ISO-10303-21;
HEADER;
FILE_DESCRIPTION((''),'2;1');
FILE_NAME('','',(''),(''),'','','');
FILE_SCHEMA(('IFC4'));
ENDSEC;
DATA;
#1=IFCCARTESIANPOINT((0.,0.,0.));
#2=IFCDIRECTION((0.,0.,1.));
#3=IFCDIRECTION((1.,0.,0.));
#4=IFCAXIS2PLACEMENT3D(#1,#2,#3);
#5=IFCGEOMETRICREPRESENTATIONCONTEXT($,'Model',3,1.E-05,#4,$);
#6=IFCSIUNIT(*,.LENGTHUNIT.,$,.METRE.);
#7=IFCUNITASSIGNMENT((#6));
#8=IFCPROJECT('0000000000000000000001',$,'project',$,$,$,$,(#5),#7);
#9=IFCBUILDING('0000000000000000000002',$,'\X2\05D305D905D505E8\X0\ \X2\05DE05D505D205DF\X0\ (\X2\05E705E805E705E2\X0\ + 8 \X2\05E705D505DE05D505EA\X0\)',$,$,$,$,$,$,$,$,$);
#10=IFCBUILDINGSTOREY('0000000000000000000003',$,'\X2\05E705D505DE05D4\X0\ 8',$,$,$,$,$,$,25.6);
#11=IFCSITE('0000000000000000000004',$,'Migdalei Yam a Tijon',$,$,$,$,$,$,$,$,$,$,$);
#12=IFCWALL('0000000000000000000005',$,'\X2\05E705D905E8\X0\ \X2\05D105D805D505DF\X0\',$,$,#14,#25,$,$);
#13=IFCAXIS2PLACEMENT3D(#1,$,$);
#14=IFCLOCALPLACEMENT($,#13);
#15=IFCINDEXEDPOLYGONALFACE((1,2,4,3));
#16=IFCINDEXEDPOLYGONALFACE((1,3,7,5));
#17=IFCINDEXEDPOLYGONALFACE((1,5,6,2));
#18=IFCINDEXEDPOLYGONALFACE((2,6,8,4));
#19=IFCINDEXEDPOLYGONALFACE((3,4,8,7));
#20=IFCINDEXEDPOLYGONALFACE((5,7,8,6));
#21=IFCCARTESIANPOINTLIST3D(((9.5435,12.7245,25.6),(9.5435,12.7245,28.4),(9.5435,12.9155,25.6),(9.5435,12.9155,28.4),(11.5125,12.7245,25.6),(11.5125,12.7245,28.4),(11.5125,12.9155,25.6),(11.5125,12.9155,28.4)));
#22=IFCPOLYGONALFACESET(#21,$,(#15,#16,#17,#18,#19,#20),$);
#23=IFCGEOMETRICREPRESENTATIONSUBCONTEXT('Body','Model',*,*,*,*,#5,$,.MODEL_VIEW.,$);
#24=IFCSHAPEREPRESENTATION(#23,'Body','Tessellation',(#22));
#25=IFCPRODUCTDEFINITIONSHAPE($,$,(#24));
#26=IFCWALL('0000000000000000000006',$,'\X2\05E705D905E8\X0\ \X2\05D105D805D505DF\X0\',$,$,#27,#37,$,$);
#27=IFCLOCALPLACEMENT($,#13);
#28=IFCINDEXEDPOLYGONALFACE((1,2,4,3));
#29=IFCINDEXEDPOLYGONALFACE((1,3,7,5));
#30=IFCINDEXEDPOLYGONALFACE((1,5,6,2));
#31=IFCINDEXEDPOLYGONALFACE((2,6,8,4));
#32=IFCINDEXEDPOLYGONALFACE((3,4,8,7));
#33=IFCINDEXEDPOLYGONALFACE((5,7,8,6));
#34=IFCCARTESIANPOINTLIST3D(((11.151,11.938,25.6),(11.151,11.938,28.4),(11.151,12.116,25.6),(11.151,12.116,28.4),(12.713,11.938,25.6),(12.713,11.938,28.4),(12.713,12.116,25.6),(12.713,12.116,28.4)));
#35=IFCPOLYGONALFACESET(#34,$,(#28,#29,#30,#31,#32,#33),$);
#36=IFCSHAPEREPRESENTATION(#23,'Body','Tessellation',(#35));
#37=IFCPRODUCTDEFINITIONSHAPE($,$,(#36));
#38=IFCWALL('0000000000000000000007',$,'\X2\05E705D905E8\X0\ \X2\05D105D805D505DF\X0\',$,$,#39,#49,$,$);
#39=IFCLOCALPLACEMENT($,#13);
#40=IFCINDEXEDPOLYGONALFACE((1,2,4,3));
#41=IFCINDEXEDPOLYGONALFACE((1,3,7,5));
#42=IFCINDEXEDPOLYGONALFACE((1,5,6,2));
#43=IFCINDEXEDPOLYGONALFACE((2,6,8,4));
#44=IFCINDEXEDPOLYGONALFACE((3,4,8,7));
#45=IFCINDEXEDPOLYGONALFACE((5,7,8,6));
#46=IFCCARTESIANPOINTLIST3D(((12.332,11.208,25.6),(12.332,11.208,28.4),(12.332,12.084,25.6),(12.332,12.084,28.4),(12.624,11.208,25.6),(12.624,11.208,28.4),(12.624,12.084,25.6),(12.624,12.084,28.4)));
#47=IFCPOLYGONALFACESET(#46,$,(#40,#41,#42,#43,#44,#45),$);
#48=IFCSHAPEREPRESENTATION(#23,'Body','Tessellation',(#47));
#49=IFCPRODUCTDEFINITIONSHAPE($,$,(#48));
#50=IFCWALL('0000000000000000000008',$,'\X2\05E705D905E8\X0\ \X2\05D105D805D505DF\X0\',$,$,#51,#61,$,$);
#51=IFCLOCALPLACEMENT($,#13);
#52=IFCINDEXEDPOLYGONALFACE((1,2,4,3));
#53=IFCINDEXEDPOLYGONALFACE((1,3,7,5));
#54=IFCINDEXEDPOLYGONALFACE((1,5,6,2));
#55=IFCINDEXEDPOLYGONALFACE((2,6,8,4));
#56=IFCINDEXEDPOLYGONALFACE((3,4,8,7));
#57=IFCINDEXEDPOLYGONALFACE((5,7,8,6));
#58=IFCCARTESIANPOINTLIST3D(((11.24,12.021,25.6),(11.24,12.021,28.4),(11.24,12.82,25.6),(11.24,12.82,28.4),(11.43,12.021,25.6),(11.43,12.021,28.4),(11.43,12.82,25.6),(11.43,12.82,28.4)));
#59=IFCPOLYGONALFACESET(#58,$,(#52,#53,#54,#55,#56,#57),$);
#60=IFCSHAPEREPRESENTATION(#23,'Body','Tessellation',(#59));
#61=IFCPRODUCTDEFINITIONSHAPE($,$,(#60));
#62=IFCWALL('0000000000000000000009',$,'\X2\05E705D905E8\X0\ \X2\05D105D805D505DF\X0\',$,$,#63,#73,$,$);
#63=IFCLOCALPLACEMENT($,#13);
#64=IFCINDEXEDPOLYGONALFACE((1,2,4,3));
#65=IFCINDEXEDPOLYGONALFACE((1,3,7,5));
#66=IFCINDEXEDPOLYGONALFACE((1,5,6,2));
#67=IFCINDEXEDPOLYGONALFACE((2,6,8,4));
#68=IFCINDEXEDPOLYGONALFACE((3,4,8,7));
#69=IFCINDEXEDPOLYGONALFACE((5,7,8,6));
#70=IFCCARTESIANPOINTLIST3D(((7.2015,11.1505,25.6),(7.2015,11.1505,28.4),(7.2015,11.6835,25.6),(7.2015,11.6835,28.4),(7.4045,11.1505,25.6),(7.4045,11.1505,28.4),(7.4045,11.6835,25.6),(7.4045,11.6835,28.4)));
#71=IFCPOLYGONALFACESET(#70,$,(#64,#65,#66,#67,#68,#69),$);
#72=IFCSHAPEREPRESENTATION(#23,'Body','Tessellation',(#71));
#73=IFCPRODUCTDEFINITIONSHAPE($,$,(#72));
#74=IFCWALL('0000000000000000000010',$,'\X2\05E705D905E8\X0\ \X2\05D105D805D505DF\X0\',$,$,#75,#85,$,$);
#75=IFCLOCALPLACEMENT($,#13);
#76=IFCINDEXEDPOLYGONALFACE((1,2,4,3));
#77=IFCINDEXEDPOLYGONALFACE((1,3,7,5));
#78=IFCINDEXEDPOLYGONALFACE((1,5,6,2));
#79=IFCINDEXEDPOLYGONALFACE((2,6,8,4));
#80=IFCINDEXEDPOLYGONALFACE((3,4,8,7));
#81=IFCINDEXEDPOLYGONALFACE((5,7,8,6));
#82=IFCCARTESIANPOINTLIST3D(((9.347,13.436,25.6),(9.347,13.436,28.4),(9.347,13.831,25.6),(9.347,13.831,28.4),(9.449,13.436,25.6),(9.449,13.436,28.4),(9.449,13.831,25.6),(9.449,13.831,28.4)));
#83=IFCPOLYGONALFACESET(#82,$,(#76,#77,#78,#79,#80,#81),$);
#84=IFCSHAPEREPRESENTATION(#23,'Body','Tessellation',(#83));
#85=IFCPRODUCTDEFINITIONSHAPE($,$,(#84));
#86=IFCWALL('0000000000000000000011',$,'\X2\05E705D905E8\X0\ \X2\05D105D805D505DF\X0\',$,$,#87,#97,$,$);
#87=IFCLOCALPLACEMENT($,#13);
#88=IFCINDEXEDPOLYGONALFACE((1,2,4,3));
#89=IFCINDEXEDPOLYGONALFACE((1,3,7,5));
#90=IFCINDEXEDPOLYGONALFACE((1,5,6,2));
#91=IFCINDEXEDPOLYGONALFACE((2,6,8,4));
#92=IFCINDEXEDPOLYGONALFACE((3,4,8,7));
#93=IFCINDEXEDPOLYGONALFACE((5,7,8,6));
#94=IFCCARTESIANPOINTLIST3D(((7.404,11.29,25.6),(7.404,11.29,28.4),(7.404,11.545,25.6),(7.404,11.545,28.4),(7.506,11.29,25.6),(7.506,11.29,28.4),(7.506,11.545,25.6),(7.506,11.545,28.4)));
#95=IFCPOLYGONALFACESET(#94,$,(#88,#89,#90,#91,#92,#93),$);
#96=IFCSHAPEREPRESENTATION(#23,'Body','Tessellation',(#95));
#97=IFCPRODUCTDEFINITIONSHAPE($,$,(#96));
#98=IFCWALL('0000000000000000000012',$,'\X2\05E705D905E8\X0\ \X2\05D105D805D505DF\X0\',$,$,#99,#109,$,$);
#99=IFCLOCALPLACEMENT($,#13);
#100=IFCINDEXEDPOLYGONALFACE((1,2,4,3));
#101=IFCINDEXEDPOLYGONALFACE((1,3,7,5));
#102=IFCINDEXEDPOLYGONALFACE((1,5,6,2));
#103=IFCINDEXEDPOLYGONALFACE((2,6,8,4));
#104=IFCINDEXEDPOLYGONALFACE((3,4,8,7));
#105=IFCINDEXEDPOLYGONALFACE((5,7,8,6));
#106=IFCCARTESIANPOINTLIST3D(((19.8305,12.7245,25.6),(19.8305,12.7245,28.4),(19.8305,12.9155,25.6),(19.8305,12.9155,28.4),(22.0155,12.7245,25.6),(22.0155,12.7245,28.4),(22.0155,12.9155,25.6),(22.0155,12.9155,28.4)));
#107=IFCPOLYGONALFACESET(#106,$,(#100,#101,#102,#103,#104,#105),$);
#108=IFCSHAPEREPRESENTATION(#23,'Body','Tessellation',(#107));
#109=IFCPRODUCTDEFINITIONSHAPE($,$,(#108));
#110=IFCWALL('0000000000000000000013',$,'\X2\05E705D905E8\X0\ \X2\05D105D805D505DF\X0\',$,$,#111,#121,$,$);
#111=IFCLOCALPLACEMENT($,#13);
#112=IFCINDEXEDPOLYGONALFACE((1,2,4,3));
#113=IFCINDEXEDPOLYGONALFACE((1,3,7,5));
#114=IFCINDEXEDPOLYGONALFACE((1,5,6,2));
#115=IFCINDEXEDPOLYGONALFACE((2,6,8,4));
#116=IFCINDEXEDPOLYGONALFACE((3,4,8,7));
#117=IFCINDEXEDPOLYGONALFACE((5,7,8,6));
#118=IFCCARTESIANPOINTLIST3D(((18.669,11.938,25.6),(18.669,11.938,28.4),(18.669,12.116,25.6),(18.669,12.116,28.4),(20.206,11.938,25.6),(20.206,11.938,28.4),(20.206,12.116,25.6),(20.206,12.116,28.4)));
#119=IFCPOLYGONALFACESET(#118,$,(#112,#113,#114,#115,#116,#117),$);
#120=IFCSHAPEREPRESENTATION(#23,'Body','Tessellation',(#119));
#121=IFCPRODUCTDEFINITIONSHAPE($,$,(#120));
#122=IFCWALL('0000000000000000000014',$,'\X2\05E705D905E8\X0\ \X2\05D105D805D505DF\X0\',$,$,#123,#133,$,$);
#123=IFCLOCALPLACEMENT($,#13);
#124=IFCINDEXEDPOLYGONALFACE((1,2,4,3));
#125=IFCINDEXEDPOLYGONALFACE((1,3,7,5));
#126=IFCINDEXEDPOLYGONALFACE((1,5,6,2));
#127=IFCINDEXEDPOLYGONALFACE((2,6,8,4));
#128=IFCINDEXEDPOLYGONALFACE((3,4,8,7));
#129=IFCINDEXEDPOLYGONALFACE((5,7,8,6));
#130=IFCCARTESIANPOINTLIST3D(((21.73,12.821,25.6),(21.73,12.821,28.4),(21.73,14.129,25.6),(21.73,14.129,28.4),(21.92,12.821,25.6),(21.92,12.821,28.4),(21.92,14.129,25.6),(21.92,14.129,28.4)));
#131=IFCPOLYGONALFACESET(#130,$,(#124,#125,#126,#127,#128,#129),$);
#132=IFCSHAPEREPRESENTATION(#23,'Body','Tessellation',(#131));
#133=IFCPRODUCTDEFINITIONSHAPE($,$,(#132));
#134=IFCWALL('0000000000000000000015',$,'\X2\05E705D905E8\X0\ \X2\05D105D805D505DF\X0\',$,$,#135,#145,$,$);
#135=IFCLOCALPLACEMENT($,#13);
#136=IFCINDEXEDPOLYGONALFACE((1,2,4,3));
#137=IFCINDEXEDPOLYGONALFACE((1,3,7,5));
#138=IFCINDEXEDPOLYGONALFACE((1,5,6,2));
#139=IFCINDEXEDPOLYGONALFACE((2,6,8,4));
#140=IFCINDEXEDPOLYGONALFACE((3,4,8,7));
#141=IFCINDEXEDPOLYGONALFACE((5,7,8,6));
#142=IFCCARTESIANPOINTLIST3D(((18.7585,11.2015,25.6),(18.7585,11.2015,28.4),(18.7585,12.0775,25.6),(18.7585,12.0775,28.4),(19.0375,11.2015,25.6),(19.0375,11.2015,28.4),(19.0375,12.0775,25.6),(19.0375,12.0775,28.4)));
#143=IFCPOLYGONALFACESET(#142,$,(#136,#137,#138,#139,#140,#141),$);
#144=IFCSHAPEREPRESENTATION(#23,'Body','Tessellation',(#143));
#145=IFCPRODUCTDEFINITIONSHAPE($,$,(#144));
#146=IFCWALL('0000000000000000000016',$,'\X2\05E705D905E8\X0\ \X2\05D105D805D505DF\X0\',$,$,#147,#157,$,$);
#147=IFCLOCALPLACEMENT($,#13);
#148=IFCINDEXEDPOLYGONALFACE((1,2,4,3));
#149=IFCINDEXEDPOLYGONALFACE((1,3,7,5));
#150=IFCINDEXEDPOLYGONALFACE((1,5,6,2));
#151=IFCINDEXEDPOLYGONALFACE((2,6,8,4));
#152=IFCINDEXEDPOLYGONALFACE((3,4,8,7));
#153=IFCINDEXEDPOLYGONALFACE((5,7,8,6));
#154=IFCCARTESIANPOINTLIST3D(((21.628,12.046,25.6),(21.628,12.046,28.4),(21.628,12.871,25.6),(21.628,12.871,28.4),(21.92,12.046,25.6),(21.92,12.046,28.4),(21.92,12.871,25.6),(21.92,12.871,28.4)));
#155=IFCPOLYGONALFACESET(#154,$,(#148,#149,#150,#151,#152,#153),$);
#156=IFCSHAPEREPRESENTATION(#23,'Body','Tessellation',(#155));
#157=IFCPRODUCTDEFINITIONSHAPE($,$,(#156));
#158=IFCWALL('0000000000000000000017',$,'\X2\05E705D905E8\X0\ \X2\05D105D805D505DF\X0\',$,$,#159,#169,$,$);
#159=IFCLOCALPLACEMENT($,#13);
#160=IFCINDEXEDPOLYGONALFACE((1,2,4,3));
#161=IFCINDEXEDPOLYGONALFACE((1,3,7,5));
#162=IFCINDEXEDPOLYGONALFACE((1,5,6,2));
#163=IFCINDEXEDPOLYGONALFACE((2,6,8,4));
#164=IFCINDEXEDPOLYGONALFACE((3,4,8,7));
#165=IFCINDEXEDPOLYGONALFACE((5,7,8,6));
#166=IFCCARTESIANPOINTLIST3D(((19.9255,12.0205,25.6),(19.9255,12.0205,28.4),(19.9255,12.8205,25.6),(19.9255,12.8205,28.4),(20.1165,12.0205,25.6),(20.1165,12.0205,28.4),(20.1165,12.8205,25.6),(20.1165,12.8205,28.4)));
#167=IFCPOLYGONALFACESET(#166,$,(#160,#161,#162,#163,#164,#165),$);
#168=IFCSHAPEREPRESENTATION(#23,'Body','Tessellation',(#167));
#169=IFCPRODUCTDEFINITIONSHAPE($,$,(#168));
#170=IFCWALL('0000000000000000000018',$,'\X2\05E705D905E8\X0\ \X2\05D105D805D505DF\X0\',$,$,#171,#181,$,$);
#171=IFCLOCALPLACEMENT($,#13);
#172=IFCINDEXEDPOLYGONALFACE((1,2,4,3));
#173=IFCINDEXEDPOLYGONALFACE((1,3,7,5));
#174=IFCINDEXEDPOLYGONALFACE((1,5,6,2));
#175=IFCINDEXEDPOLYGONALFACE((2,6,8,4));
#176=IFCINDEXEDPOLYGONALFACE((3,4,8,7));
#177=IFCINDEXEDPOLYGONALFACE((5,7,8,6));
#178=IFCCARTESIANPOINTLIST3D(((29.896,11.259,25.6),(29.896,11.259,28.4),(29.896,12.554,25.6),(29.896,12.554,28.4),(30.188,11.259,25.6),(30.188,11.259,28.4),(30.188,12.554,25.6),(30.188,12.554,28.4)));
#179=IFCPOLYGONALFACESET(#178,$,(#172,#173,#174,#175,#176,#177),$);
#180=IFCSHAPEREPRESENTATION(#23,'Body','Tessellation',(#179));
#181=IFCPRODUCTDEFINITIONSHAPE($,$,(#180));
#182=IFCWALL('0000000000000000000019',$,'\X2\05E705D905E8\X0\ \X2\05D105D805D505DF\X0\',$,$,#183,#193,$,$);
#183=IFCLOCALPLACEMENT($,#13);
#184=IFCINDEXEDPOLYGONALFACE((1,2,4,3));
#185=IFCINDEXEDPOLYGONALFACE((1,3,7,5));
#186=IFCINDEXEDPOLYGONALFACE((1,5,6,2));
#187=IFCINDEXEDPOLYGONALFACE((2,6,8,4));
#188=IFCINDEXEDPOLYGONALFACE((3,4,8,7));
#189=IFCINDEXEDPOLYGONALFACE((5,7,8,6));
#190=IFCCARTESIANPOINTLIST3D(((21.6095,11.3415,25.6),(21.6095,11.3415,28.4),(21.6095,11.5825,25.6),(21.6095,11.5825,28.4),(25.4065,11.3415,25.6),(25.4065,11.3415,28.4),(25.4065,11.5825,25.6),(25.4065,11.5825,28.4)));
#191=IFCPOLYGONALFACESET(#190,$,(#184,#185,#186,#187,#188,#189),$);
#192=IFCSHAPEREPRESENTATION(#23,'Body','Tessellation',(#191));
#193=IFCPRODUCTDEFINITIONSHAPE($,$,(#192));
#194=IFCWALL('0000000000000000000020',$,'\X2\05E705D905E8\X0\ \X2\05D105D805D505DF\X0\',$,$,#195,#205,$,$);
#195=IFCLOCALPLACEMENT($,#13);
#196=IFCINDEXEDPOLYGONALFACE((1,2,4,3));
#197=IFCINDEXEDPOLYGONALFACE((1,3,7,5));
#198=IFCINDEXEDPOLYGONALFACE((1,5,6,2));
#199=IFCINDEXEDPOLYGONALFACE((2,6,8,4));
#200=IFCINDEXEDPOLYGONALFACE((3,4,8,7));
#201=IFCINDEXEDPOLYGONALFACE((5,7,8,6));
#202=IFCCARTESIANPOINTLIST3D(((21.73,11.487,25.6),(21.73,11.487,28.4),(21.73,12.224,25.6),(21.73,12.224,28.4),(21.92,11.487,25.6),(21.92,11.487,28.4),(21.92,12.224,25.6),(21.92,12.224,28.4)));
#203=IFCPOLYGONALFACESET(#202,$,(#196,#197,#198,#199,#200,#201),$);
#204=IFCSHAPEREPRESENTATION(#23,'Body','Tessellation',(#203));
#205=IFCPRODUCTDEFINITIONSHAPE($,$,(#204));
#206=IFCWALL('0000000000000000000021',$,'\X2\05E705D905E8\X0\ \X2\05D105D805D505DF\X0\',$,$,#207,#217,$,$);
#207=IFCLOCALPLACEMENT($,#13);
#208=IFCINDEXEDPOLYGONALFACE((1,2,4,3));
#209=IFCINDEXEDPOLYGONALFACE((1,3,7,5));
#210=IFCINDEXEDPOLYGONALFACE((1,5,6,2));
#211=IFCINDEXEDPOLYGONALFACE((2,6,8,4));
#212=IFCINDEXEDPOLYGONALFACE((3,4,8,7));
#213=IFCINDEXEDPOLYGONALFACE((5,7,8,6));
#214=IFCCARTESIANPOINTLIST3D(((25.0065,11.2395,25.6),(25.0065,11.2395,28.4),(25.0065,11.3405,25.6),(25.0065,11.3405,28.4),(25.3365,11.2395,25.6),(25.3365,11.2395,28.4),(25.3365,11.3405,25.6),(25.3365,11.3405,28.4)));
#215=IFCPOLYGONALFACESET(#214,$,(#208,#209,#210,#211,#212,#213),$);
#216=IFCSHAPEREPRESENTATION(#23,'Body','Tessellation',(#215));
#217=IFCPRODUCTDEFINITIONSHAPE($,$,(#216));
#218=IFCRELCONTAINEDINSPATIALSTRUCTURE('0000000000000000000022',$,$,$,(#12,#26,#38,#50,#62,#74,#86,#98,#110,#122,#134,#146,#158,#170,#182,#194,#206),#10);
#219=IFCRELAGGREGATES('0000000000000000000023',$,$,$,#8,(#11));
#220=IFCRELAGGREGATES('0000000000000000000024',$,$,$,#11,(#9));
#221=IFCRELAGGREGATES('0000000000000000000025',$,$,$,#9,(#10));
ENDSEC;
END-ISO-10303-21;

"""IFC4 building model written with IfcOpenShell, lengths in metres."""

from ifc_helpers import new_model, si_unit, frame, origin_with_axes, context, subcontext, project, spatial, line, indexed_curve, outline, extrude, element, save


model = new_model("IFC4")

# Units and contexts
model_context = context("Model", 3, precision=1e-05, world=origin_with_axes())
body_context = subcontext(model_context, "Body", "Model", "MODEL_VIEW")
ifc_project = project(units=[si_unit("LENGTHUNIT", "METRE")], contexts=[model_context])

# Site, building, storey
site = spatial("IfcSite", under=ifc_project, Name="Migdalei Yam a Tijon")
building = spatial("IfcBuilding", under=site, Name="דיור מוגן (קרקע + 8 קומות)")
storey = spatial("IfcBuildingStorey", under=building, Name="קומה 8", Elevation=25.6)

# Walls
element("IfcWall", 1, inside=storey, Name="קיר בטון", context=body_context, shape_type="SweptSolid", body=[
    extrude(outline(indexed_curve([(0.0, 0.0), (1.969, 0.0), (1.969, 0.191), (0.0, 0.191)], segments=[line(1, 2, 3, 4, 1)])), frame((9.5435, 12.7245, 25.6), z_axis=(0.0, 0.0, 1.0), x_axis=(1.0, 0.0, 0.0)), (0.0, 0.0, 1.0), 2.8),
])
element("IfcWall", 2, inside=storey, Name="קיר בטון", context=body_context, shape_type="SweptSolid", body=[
    extrude(outline(indexed_curve([(0.0, 0.0), (1.562, 0.0), (1.562, 0.178), (0.0, 0.178)], segments=[line(1, 2, 3, 4, 1)])), frame((11.151, 11.938, 25.6), z_axis=(0.0, 0.0, 1.0), x_axis=(1.0, 0.0, 0.0)), (0.0, 0.0, 1.0), 2.8),
])
element("IfcWall", 3, inside=storey, Name="קיר בטון", context=body_context, shape_type="SweptSolid", body=[
    extrude(outline(indexed_curve([(0.0, 0.0), (0.292, 0.0), (0.292, 0.876), (0.0, 0.876)], segments=[line(1, 2, 3, 4, 1)])), frame((12.332, 11.208, 25.6), z_axis=(0.0, 0.0, 1.0), x_axis=(1.0, 0.0, 0.0)), (0.0, 0.0, 1.0), 2.8),
])
element("IfcWall", 4, inside=storey, Name="קיר בטון", context=body_context, shape_type="SweptSolid", body=[
    extrude(outline(indexed_curve([(0.0, 0.0), (0.19, 0.0), (0.19, 0.799), (0.0, 0.799)], segments=[line(1, 2, 3, 4, 1)])), frame((11.24, 12.021, 25.6), z_axis=(0.0, 0.0, 1.0), x_axis=(1.0, 0.0, 0.0)), (0.0, 0.0, 1.0), 2.8),
])
element("IfcWall", 5, inside=storey, Name="קיר בטון", context=body_context, shape_type="SweptSolid", body=[
    extrude(outline(indexed_curve([(0.0, 0.0), (0.203, 0.0), (0.203, 0.533), (0.0, 0.533)], segments=[line(1, 2, 3, 4, 1)])), frame((7.2015, 11.1505, 25.6), z_axis=(0.0, 0.0, 1.0), x_axis=(1.0, 0.0, 0.0)), (0.0, 0.0, 1.0), 2.8),
])
element("IfcWall", 6, inside=storey, Name="קיר בטון", context=body_context, shape_type="SweptSolid", body=[
    extrude(outline(indexed_curve([(0.0, 0.0), (0.102, 0.0), (0.102, 0.395), (0.0, 0.395)], segments=[line(1, 2, 3, 4, 1)])), frame((9.347, 13.436, 25.6), z_axis=(0.0, 0.0, 1.0), x_axis=(1.0, 0.0, 0.0)), (0.0, 0.0, 1.0), 2.8),
])
element("IfcWall", 7, inside=storey, Name="קיר בטון", context=body_context, shape_type="SweptSolid", body=[
    extrude(outline(indexed_curve([(0.0, 0.0), (0.102, 0.0), (0.102, 0.255), (0.0, 0.255)], segments=[line(1, 2, 3, 4, 1)])), frame((7.404, 11.29, 25.6), z_axis=(0.0, 0.0, 1.0), x_axis=(1.0, 0.0, 0.0)), (0.0, 0.0, 1.0), 2.8),
])
element("IfcWall", 8, inside=storey, Name="קיר בטון", context=body_context, shape_type="SweptSolid", body=[
    extrude(outline(indexed_curve([(0.0, 0.0), (2.185, 0.0), (2.185, 0.191), (0.0, 0.191)], segments=[line(1, 2, 3, 4, 1)])), frame((19.8305, 12.7245, 25.6), z_axis=(0.0, 0.0, 1.0), x_axis=(1.0, 0.0, 0.0)), (0.0, 0.0, 1.0), 2.8),
])
element("IfcWall", 9, inside=storey, Name="קיר בטון", context=body_context, shape_type="SweptSolid", body=[
    extrude(outline(indexed_curve([(0.0, 0.0), (1.537, 0.0), (1.537, 0.178), (0.0, 0.178)], segments=[line(1, 2, 3, 4, 1)])), frame((18.669, 11.938, 25.6), z_axis=(0.0, 0.0, 1.0), x_axis=(1.0, 0.0, 0.0)), (0.0, 0.0, 1.0), 2.8),
])
element("IfcWall", 10, inside=storey, Name="קיר בטון", context=body_context, shape_type="SweptSolid", body=[
    extrude(outline(indexed_curve([(0.0, 0.0), (0.19, 0.0), (0.19, 1.308), (0.0, 1.308)], segments=[line(1, 2, 3, 4, 1)])), frame((21.73, 12.821, 25.6), z_axis=(0.0, 0.0, 1.0), x_axis=(1.0, 0.0, 0.0)), (0.0, 0.0, 1.0), 2.8),
])
element("IfcWall", 11, inside=storey, Name="קיר בטון", context=body_context, shape_type="SweptSolid", body=[
    extrude(outline(indexed_curve([(0.0, 0.0), (0.279, 0.0), (0.279, 0.876), (0.0, 0.876)], segments=[line(1, 2, 3, 4, 1)])), frame((18.7585, 11.2015, 25.6), z_axis=(0.0, 0.0, 1.0), x_axis=(1.0, 0.0, 0.0)), (0.0, 0.0, 1.0), 2.8),
])
element("IfcWall", 12, inside=storey, Name="קיר בטון", context=body_context, shape_type="SweptSolid", body=[
    extrude(outline(indexed_curve([(0.0, 0.0), (0.292, 0.0), (0.292, 0.825), (0.0, 0.825)], segments=[line(1, 2, 3, 4, 1)])), frame((21.628, 12.046, 25.6), z_axis=(0.0, 0.0, 1.0), x_axis=(1.0, 0.0, 0.0)), (0.0, 0.0, 1.0), 2.8),
])
element("IfcWall", 13, inside=storey, Name="קיר בטון", context=body_context, shape_type="SweptSolid", body=[
    extrude(outline(indexed_curve([(0.0, 0.0), (0.191, 0.0), (0.191, 0.8), (0.0, 0.8)], segments=[line(1, 2, 3, 4, 1)])), frame((19.9255, 12.0205, 25.6), z_axis=(0.0, 0.0, 1.0), x_axis=(1.0, 0.0, 0.0)), (0.0, 0.0, 1.0), 2.8),
])
element("IfcWall", 14, inside=storey, Name="קיר בטון", context=body_context, shape_type="SweptSolid", body=[
    extrude(outline(indexed_curve([(0.0, 0.0), (0.292, 0.0), (0.292, 1.295), (0.0, 1.295)], segments=[line(1, 2, 3, 4, 1)])), frame((29.896, 11.259, 25.6), z_axis=(0.0, 0.0, 1.0), x_axis=(1.0, 0.0, 0.0)), (0.0, 0.0, 1.0), 2.8),
])
element("IfcWall", 15, inside=storey, Name="קיר בטון", context=body_context, shape_type="SweptSolid", body=[
    extrude(outline(indexed_curve([(0.0, 0.0), (3.797, 0.0), (3.797, 0.241), (0.0, 0.241)], segments=[line(1, 2, 3, 4, 1)])), frame((21.6095, 11.3415, 25.6), z_axis=(0.0, 0.0, 1.0), x_axis=(1.0, 0.0, 0.0)), (0.0, 0.0, 1.0), 2.8),
])
element("IfcWall", 16, inside=storey, Name="קיר בטון", context=body_context, shape_type="SweptSolid", body=[
    extrude(outline(indexed_curve([(0.0, 0.0), (0.19, 0.0), (0.19, 0.737), (0.0, 0.737)], segments=[line(1, 2, 3, 4, 1)])), frame((21.73, 11.487, 25.6), z_axis=(0.0, 0.0, 1.0), x_axis=(1.0, 0.0, 0.0)), (0.0, 0.0, 1.0), 2.8),
])
element("IfcWall", 17, inside=storey, Name="קיר בטון", context=body_context, shape_type="SweptSolid", body=[
    extrude(outline(indexed_curve([(0.0, 0.0), (0.33, 0.0), (0.33, 0.101), (0.0, 0.101)], segments=[line(1, 2, 3, 4, 1)])), frame((25.0065, 11.2395, 25.6), z_axis=(0.0, 0.0, 1.0), x_axis=(1.0, 0.0, 0.0)), (0.0, 0.0, 1.0), 2.8),
])

save(model, "model.ifc")
